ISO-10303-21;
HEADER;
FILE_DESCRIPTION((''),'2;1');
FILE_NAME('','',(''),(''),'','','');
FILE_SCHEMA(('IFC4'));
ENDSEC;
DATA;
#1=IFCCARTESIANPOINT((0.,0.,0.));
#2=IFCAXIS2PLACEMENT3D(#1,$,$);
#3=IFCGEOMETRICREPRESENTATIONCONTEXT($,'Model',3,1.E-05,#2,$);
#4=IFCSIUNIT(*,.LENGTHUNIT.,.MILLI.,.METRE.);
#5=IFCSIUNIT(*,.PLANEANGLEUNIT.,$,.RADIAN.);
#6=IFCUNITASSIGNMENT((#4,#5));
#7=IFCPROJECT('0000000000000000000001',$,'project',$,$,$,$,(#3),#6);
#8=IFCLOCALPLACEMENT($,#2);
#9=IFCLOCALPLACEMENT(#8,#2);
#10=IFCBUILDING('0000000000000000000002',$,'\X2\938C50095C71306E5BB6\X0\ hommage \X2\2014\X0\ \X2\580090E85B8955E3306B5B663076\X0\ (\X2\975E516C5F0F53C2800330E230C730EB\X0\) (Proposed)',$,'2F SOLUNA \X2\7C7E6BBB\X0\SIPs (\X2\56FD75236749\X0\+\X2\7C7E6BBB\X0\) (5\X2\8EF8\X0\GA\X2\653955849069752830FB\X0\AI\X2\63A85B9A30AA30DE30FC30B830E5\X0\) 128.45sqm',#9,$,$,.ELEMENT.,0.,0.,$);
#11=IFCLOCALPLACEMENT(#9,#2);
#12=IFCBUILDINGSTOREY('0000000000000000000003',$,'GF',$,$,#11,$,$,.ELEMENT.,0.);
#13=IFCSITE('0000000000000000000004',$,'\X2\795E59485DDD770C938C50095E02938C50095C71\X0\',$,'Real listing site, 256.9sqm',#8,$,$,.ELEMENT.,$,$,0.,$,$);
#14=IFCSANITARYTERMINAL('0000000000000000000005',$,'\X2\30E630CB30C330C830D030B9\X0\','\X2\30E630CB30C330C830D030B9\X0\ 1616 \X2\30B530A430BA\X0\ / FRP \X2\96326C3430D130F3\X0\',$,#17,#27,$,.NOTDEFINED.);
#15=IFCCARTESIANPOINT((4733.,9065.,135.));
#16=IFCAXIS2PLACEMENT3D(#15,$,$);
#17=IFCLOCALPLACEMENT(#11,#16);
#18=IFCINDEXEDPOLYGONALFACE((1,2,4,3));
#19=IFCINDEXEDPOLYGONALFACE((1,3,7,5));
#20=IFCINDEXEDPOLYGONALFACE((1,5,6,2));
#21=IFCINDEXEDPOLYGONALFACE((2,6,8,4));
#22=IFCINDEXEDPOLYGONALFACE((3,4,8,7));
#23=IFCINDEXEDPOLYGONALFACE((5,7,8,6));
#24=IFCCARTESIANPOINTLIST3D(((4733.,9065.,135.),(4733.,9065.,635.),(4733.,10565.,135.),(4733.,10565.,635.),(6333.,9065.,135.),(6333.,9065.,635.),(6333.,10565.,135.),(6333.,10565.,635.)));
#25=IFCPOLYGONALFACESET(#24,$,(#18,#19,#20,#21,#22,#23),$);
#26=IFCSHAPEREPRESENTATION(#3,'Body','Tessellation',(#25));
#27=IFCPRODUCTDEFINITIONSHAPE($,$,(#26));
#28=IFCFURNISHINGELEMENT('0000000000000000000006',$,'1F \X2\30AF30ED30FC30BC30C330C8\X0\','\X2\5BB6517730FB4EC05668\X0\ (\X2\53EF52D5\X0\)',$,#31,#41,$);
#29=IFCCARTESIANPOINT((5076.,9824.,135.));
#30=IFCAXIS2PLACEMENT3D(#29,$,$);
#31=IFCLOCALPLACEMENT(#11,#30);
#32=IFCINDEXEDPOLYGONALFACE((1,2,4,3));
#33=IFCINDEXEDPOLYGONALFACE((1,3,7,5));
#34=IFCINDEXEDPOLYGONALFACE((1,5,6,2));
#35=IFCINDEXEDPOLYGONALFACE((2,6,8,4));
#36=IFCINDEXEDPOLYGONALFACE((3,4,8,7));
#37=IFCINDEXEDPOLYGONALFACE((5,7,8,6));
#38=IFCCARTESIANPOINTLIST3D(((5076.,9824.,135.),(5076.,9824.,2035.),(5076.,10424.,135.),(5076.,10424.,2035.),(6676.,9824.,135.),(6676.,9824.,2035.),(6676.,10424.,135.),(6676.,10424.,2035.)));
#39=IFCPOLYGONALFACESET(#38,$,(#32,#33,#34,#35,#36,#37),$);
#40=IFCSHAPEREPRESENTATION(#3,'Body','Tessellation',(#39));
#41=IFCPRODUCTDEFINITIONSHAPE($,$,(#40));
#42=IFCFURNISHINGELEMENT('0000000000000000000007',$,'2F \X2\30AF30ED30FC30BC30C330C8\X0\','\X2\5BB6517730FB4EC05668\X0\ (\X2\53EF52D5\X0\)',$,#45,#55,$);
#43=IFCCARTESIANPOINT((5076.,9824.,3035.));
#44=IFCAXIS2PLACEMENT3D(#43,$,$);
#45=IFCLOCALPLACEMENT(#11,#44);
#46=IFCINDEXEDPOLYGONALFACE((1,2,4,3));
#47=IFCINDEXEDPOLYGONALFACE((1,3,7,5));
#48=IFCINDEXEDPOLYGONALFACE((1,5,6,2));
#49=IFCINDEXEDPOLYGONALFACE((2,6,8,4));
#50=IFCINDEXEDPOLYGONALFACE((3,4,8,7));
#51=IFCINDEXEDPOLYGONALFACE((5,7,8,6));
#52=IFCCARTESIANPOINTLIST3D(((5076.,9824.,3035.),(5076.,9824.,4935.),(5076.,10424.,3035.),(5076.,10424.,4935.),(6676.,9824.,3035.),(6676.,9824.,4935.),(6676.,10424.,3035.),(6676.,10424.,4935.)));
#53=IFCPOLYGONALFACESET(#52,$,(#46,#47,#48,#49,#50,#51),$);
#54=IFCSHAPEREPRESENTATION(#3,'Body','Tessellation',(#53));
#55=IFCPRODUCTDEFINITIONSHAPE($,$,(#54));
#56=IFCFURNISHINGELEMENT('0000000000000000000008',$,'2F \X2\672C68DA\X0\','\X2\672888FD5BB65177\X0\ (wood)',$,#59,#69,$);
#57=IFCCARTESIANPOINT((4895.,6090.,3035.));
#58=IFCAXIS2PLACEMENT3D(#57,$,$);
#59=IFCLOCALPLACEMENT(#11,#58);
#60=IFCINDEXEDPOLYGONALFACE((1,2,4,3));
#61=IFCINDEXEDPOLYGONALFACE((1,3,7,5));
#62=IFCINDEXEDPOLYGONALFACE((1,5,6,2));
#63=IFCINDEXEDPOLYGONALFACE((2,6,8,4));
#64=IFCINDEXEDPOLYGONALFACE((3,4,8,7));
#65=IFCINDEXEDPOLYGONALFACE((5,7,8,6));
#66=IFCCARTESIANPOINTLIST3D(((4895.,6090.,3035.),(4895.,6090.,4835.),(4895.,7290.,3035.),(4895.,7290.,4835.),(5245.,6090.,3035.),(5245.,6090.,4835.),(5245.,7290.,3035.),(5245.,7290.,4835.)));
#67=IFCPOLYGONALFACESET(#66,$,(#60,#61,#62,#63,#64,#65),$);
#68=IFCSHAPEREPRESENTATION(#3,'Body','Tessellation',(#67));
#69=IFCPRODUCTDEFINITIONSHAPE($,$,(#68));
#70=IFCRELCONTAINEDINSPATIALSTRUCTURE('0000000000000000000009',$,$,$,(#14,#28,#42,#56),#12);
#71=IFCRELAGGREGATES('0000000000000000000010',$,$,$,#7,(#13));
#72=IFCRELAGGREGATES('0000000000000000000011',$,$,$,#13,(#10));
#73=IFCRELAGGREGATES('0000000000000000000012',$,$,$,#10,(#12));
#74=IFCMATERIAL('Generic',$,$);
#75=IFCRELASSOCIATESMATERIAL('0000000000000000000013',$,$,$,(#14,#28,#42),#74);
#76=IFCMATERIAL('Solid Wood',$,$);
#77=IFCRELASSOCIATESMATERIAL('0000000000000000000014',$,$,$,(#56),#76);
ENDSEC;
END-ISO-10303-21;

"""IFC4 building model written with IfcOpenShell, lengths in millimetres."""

from ifc_helpers import new_model, si_unit, frame, frame_2d, origin, place, context, project, spatial, rectangle, extrude, material, element, save


model = new_model("IFC4")

# Units and contexts
model_context = context("Model", 3, precision=1e-05, world=origin())
ifc_project = project(units=[si_unit("LENGTHUNIT", "METRE", prefix="MILLI"), si_unit("PLANEANGLEUNIT", "RADIAN")], contexts=[model_context])

# Site, building, storey
site_placement = place(None, origin())
site = spatial("IfcSite", under=ifc_project, at=site_placement, Name="神奈川県鎌倉市鎌倉山", ObjectType="Real listing site, 256.9sqm", CompositionType="ELEMENT", RefElevation=0.0)
building_placement = place(site_placement, origin())
building = spatial("IfcBuilding", under=site, at=building_placement, Name="鎌倉山の家 hommage — 堀部安嗣に学ぶ (非公式参考モデル) (Proposed)", ObjectType="2F SOLUNA 籾殻SIPs (国産杉+籾殻) (5軸GA改善適用・AI推定オマージュ) 128.45sqm", CompositionType="ELEMENT", ElevationOfRefHeight=0.0, ElevationOfTerrain=0.0)
storey_placement = place(building_placement, origin())
storey = spatial("IfcBuildingStorey", under=building, at=storey_placement, Name="GF", CompositionType="ELEMENT", Elevation=0.0)

# Shared definitions
ifc_material_1 = material(Name="Solid Wood")

# Shared definitions
ifc_material_2 = material(Name="Generic")

# Sanitary terminal
sanitary_terminal_placement = place(storey_placement, frame((4733.0, 9065.0, 135.0)))
element("IfcSanitaryTerminal", 1, at=sanitary_terminal_placement, inside=storey, material=ifc_material_2, Name="ユニットバス", Description="ユニットバス 1616 サイズ / FRP 防水パン", PredefinedType="NOTDEFINED", context=model_context, shape_type="SweptSolid", body=[
    extrude(rectangle(XDim=1600.0, YDim=1500.0, at=frame_2d((800.0, 750.0))), frame((4733.0, 9065.0, 135.0)), (0.0, 0.0, 1.0), 500.0),
])

# Furnishing elements
furnishing_1_placement = place(storey_placement, frame((5076.0, 9824.0, 135.0)))
element("IfcFurnishingElement", 2, at=furnishing_1_placement, inside=storey, material=ifc_material_2, Name="1F クローゼット", Description="家具・什器 (可動)", context=model_context, shape_type="SweptSolid", body=[
    extrude(rectangle(XDim=1600.0, YDim=600.0, at=frame_2d((800.0, 300.0))), frame((5076.0, 9824.0, 135.0)), (0.0, 0.0, 1.0), 1900.0),
])
furnishing_2_placement = place(storey_placement, frame((5076.0, 9824.0, 3035.0)))
element("IfcFurnishingElement", 3, at=furnishing_2_placement, inside=storey, material=ifc_material_2, Name="2F クローゼット", Description="家具・什器 (可動)", context=model_context, shape_type="SweptSolid", body=[
    extrude(rectangle(XDim=1600.0, YDim=600.0, at=frame_2d((800.0, 300.0))), frame((5076.0, 9824.0, 3035.0)), (0.0, 0.0, 1.0), 1900.0),
])
furnishing_3_placement = place(storey_placement, frame((4895.0, 6090.0, 3035.0)))
element("IfcFurnishingElement", 4, at=furnishing_3_placement, inside=storey, material=ifc_material_1, Name="2F 本棚", Description="木製家具 (wood)", context=model_context, shape_type="SweptSolid", body=[
    extrude(rectangle(XDim=350.0, YDim=1200.0, at=frame_2d((175.0, 600.0))), frame((4895.0, 6090.0, 3035.0)), (0.0, 0.0, 1.0), 1800.0),
])

save(model, "model.ifc")
